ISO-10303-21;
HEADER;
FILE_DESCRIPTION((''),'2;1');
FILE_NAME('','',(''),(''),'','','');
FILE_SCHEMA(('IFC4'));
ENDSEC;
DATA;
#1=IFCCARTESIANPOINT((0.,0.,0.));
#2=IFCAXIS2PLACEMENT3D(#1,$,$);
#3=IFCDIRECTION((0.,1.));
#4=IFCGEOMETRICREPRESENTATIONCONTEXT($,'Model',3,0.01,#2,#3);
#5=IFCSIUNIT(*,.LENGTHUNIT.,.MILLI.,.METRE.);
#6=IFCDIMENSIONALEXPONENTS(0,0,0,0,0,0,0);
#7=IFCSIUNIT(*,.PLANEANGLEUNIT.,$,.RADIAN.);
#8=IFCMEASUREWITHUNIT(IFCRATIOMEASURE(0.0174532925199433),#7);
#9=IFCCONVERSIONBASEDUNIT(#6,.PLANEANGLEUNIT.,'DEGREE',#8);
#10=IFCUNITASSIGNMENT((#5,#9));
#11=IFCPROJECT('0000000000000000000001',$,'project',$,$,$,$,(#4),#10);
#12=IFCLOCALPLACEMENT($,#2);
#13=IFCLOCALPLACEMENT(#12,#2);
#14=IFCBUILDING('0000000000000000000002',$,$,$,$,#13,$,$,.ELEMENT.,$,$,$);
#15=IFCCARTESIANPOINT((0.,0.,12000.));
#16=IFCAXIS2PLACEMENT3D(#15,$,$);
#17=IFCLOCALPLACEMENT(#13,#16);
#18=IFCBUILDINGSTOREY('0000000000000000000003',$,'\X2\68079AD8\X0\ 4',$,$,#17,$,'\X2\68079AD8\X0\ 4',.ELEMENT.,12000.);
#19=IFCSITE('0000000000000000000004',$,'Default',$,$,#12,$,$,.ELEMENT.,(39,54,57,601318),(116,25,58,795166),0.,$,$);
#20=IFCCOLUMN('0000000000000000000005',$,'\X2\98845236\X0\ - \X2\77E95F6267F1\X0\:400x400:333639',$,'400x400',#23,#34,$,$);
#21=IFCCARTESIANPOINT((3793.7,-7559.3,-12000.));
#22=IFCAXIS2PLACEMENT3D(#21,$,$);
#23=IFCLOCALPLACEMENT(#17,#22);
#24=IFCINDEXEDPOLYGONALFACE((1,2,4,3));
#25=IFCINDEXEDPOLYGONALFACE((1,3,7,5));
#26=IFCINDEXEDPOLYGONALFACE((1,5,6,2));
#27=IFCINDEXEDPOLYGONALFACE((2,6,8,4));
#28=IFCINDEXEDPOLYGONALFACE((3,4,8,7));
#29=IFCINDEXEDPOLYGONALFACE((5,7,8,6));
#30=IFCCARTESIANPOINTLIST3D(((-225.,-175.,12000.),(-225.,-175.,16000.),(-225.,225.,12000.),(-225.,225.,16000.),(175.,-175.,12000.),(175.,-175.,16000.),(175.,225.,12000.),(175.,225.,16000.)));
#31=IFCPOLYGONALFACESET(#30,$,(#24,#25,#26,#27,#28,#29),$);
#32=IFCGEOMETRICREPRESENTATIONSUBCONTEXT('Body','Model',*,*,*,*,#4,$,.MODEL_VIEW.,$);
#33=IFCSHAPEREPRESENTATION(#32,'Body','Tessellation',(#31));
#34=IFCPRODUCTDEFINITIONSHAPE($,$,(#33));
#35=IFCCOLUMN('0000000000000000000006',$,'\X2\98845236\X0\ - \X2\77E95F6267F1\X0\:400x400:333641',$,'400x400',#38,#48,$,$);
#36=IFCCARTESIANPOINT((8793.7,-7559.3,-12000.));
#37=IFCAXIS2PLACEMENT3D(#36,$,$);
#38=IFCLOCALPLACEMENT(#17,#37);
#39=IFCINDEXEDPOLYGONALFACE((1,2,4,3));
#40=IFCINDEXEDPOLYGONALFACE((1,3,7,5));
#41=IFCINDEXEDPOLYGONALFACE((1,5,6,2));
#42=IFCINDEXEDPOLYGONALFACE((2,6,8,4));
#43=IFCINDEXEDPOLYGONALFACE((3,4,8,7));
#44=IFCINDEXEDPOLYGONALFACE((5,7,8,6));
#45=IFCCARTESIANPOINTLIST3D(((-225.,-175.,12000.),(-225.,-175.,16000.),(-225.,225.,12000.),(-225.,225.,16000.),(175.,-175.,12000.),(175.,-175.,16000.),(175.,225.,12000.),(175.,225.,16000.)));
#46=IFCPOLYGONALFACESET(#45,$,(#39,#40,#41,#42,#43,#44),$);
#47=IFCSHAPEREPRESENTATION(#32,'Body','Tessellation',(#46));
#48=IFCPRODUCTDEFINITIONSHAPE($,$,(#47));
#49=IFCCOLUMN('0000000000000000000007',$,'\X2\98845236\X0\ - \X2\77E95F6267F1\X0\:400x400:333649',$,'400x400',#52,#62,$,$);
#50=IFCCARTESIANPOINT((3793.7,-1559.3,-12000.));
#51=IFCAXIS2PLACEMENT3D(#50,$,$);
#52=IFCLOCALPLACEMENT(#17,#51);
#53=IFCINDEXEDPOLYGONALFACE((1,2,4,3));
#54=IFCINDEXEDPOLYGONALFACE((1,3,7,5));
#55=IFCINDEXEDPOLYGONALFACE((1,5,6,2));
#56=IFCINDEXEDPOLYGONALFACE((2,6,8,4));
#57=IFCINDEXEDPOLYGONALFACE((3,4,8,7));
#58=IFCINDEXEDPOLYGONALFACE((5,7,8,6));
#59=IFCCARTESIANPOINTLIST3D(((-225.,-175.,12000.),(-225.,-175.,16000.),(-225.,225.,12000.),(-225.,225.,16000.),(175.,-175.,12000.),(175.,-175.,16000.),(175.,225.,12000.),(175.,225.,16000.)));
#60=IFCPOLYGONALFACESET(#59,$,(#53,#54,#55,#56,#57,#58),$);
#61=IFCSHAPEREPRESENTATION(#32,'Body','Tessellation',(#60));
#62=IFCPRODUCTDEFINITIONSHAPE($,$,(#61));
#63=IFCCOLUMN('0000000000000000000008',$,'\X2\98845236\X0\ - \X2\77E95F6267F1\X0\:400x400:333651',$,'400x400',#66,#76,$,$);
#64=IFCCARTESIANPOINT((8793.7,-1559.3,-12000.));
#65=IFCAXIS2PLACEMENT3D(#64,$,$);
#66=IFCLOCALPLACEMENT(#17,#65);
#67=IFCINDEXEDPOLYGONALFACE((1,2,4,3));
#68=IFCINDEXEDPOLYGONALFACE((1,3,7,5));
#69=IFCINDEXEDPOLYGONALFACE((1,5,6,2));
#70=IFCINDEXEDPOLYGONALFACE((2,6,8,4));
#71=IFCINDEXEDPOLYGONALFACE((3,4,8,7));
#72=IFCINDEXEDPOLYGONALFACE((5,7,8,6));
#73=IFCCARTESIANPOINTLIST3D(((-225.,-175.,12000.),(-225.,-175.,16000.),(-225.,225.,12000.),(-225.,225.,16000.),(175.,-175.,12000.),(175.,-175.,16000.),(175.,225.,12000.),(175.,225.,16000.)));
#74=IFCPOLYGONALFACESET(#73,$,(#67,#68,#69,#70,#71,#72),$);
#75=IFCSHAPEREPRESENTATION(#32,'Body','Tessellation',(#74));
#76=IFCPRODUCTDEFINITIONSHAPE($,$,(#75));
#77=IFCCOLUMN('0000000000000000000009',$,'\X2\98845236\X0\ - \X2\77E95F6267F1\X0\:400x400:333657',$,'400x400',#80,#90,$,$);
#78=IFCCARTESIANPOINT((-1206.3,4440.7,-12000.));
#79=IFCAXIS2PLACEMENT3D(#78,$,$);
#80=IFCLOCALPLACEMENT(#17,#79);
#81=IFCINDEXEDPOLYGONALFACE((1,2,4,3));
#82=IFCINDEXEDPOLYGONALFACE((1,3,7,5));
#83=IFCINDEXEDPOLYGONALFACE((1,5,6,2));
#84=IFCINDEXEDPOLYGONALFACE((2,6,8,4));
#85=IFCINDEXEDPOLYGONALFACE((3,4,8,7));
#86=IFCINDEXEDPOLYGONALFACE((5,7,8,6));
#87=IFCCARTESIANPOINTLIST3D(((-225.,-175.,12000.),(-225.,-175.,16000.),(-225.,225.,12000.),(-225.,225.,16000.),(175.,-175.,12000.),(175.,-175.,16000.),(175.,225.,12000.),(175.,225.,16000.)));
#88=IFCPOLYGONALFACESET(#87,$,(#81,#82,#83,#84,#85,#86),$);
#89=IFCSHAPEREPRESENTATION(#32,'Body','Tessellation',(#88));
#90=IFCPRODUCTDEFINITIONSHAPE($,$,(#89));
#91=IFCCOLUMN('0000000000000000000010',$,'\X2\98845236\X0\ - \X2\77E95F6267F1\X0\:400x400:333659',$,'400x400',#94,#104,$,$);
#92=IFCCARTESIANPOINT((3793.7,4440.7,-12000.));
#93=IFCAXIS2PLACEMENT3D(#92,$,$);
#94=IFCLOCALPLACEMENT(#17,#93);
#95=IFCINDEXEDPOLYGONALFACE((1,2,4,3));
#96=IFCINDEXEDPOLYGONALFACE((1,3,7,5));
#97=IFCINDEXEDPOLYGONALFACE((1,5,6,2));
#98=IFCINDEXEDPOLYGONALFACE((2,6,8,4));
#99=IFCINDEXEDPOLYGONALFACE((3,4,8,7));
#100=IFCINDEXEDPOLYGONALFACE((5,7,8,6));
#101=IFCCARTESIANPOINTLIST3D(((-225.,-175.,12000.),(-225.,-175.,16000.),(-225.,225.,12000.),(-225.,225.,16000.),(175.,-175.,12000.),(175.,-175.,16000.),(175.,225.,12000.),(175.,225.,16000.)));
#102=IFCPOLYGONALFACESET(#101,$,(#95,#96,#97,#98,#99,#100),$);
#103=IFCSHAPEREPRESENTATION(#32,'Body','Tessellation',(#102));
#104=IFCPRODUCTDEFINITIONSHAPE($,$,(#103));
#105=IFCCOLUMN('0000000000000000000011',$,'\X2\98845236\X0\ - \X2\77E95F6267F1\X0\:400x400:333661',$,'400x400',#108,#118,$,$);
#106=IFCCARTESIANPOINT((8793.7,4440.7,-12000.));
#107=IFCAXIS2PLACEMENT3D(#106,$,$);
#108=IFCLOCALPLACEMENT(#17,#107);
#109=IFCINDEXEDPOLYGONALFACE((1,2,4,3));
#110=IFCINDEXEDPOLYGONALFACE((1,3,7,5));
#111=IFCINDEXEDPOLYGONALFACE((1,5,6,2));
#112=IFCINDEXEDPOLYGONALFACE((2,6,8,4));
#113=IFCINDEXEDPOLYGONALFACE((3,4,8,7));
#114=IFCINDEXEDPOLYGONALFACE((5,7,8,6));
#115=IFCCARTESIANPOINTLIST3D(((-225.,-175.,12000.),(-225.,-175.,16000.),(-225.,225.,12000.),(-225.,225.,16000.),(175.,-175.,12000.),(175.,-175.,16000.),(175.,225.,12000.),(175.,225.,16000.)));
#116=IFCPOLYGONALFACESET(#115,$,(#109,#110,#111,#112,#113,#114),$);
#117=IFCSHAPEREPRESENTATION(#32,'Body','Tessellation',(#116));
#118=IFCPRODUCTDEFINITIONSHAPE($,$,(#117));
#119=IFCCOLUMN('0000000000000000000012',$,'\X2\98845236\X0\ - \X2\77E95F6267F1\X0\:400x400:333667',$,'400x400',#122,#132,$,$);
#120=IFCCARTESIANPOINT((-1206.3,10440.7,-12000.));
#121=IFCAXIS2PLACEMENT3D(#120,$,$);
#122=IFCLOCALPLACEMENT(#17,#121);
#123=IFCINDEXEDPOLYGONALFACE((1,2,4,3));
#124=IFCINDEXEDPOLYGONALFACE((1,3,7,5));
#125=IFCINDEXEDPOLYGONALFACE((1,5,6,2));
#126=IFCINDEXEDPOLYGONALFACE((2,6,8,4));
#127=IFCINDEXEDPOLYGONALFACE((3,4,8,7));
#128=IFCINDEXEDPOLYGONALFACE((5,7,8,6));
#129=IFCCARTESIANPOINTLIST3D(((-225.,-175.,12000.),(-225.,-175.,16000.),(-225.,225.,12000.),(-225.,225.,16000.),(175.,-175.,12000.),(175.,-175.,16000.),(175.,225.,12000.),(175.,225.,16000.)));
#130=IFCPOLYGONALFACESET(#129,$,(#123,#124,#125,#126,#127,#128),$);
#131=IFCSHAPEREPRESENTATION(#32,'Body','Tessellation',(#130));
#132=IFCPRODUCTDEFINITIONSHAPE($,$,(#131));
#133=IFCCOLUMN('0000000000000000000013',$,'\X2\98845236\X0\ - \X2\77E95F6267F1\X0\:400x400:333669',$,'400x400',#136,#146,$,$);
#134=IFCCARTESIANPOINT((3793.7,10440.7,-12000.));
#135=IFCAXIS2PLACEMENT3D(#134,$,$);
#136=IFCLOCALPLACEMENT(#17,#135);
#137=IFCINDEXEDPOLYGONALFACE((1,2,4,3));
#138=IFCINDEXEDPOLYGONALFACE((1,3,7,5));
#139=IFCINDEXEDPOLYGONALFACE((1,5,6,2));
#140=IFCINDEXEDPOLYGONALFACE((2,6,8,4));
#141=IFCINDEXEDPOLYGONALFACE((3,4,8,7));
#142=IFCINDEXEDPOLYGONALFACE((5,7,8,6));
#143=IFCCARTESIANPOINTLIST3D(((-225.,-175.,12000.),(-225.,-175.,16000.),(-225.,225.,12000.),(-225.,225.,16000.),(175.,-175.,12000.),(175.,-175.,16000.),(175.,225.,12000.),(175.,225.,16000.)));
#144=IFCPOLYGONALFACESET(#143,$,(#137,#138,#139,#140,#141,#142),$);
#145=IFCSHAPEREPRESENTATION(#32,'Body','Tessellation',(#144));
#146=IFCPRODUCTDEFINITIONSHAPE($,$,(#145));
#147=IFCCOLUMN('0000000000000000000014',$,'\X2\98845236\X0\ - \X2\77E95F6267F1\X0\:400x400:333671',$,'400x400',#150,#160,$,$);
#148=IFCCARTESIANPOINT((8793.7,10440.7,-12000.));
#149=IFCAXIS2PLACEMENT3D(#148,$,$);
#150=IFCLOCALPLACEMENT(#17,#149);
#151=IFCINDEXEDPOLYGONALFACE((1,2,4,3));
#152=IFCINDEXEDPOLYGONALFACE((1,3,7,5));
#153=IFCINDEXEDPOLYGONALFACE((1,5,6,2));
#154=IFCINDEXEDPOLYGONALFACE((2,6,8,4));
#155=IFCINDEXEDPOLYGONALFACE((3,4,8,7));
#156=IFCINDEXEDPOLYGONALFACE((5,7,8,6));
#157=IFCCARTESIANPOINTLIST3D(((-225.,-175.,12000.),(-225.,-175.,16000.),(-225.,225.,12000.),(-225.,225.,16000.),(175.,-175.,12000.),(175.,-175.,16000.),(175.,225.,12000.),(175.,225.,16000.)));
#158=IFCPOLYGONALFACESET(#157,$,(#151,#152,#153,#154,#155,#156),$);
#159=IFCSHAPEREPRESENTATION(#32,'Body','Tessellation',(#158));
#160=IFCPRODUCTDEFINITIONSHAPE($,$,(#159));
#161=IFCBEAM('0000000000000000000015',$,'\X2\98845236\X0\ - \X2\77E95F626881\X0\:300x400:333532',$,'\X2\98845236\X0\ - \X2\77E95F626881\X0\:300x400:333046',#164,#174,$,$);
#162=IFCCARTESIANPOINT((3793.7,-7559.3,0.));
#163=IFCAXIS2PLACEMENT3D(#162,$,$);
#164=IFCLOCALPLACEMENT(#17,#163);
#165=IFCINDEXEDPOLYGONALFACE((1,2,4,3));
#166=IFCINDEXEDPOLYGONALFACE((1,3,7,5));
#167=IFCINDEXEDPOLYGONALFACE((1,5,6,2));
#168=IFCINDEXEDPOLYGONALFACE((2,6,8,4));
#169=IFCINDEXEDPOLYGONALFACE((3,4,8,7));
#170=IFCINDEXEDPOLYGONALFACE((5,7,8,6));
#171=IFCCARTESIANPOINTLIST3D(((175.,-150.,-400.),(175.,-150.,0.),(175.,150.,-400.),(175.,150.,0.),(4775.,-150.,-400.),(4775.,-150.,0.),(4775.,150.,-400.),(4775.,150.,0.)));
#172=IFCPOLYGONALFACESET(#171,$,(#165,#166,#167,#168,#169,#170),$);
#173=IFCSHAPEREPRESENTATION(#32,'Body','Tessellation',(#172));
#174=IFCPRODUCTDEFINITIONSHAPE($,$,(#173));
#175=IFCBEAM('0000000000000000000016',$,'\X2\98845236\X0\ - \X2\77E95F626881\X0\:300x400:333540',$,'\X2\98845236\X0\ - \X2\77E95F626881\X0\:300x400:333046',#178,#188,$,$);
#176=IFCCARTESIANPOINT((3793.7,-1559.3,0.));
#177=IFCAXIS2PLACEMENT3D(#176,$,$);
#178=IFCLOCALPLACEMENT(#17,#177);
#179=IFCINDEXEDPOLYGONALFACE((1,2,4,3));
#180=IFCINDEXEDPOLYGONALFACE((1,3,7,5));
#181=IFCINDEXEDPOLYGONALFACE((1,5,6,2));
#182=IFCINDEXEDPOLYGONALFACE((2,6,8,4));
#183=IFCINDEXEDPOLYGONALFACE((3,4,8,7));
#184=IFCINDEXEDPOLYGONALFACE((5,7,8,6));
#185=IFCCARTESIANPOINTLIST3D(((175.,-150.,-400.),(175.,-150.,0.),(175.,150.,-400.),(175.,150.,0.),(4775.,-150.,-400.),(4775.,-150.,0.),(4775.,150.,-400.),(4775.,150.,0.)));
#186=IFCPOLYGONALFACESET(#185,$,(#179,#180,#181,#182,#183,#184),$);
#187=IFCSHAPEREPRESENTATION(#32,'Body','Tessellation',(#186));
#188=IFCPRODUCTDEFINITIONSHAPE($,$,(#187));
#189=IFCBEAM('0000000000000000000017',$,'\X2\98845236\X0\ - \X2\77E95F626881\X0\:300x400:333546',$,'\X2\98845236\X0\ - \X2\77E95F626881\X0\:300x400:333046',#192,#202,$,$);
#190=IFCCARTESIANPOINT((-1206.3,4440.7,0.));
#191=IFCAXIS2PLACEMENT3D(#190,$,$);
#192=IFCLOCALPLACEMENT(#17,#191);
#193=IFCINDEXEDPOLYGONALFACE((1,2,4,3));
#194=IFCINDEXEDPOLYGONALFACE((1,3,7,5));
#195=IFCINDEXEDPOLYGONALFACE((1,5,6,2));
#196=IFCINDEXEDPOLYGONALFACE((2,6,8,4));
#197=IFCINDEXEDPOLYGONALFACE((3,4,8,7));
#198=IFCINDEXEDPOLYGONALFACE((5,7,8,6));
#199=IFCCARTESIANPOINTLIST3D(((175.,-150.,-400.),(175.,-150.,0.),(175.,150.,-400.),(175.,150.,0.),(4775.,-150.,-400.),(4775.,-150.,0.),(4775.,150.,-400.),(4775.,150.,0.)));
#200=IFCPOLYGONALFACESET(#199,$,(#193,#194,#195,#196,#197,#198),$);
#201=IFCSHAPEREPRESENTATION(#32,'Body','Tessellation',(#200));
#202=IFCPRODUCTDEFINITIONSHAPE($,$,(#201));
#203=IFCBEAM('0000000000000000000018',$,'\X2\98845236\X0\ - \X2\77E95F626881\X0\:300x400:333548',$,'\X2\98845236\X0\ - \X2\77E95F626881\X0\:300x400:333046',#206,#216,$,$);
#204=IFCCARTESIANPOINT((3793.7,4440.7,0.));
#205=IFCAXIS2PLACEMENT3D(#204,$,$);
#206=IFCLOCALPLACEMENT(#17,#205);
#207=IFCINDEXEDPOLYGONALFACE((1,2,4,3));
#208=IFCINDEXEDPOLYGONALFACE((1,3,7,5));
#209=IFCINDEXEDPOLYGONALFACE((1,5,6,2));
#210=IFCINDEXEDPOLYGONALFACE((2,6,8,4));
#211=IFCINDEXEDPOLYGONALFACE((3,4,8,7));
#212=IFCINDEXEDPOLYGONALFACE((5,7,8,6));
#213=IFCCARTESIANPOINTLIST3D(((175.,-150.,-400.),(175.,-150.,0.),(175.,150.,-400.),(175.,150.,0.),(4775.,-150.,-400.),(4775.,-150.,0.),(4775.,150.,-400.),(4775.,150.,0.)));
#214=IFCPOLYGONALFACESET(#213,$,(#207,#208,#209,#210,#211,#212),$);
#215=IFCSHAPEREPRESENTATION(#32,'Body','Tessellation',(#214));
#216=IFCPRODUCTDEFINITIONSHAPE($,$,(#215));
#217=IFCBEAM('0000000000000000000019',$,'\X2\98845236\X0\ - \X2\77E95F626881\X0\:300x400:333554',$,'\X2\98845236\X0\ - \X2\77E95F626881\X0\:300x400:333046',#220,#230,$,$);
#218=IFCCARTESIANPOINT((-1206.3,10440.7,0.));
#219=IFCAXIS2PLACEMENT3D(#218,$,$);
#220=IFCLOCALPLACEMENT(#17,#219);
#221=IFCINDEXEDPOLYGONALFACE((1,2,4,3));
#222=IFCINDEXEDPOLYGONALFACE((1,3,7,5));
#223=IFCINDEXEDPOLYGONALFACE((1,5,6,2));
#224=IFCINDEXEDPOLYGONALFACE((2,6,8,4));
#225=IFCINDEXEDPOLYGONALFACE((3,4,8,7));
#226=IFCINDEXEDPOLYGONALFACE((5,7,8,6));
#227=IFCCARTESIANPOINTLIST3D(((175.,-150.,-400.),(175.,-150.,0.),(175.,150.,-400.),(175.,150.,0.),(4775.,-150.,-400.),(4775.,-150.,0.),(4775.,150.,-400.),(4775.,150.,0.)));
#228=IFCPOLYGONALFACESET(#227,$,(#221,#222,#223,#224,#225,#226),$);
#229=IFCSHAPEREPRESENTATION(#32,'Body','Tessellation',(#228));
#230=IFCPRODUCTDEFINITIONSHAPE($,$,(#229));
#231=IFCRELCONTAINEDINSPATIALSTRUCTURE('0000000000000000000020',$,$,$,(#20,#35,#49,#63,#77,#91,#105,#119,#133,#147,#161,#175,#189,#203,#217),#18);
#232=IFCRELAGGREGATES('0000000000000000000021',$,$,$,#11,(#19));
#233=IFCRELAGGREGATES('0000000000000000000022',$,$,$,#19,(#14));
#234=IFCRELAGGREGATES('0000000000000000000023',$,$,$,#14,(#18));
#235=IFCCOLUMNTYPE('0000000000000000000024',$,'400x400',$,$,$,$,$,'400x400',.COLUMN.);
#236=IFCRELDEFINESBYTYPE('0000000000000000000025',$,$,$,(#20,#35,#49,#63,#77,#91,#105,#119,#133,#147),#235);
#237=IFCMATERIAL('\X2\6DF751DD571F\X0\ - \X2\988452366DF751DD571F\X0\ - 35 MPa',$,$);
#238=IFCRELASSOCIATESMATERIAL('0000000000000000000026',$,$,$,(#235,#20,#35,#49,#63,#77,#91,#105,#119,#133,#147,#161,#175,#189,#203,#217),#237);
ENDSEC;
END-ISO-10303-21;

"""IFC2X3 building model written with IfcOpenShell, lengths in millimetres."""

from ifc_helpers import new_model, entity, si_unit, converted_unit, direction, frame, frame_2d, origin, place, context, subcontext, project, spatial, rectangle, extrude, source, transform, mapped, material, type_object, type_shapes, element, save


model = new_model("IFC2X3")

# Units and contexts
model_context = context("Model", 3, precision=0.01, world=origin(), true_north=direction((0.0, 1.0)))
body_context = subcontext(model_context, "Body", "Model", "MODEL_VIEW")
ifc_project = project(units=[si_unit("LENGTHUNIT", "METRE", prefix="MILLI"), converted_unit("PLANEANGLEUNIT", "DEGREE", entity("IfcRatioMeasure", 0.0174532925199433), si_unit("PLANEANGLEUNIT", "RADIAN"), dimensions=[0, 0, 0, 0, 0, 0, 0])], contexts=[model_context])

# Site, building, storey
site_placement = place(None, origin())
site = spatial("IfcSite", under=ifc_project, at=site_placement, Name="Default", CompositionType="ELEMENT", RefLatitude=(39, 54, 57, 601318), RefLongitude=(116, 25, 58, 795166), RefElevation=0.0)
building_placement = place(site_placement, origin())
building = spatial("IfcBuilding", under=site, at=building_placement, CompositionType="ELEMENT")
storey_placement = place(building_placement, frame((0.0, 0.0, 12000.0)))
storey = spatial("IfcBuildingStorey", under=building, at=storey_placement, Name="标高 4", LongName="标高 4", CompositionType="ELEMENT", Elevation=12000.0)

# Columns
ifc_material_1 = material(Name="混凝土 - 预制混凝土 - 35 MPa")
column_type = type_object("IfcColumnType", Name="400x400", ElementType="400x400", PredefinedType="COLUMN", material=ifc_material_1)
shared_shape = source(origin(), body_context, "Body", "SweptSolid", [
    extrude(rectangle(XDim=400.0, YDim=400.0, at=frame_2d((0.0, 0.0), x_axis=(1.0, 0.0))), frame((-25.0, 25.0, 12000.0)), (0.0, 0.0, 1.0), 4000.0),
])
type_shapes(column_type, [shared_shape])
for number, where, name in (
    (1, (3793.7, -7559.3, -12000.0), "预制 - 矩形柱:400x400:333639"),
    (2, (8793.7, -7559.3, -12000.0), "预制 - 矩形柱:400x400:333641"),
    (3, (3793.7, -1559.3, -12000.0), "预制 - 矩形柱:400x400:333649"),
    (4, (8793.7, -1559.3, -12000.0), "预制 - 矩形柱:400x400:333651"),
    (5, (-1206.3, 4440.7, -12000.0), "预制 - 矩形柱:400x400:333657"),
    (6, (3793.7, 4440.7, -12000.0), "预制 - 矩形柱:400x400:333659"),
    (7, (8793.7, 4440.7, -12000.0), "预制 - 矩形柱:400x400:333661"),
    (8, (-1206.3, 10440.7, -12000.0), "预制 - 矩形柱:400x400:333667"),
    (9, (3793.7, 10440.7, -12000.0), "预制 - 矩形柱:400x400:333669"),
    (10, (8793.7, 10440.7, -12000.0), "预制 - 矩形柱:400x400:333671"),
):
    element("IfcColumn", number, at=place(storey_placement, frame(where)), inside=storey, type_object=column_type, material=ifc_material_1, Name=name, ObjectType="400x400", context=body_context, shape_type="MappedRepresentation", body=[
        mapped(shared_shape, transform((0.0, 0.0, 0.0), scale=1.0)),
    ])

# Beams
beam_1_placement = place(storey_placement, frame((3793.7, -7559.3, 0.0)))
element("IfcBeam", 11, at=beam_1_placement, inside=storey, material=ifc_material_1, Name="预制 - 矩形梁:300x400:333532", ObjectType="预制 - 矩形梁:300x400:333046", context=body_context, shape_type="SweptSolid", body=[
    extrude(rectangle(XDim=400.0, YDim=300.0, at=frame_2d((0.0, 0.0), x_axis=(1.0, 0.0))), frame((175.0, 0.0, -200.0), z_axis=(1.0, 0.0, 0.0), x_axis=(0.0, 0.0, -1.0)), (0.0, 0.0, 1.0), 4600.0),
])
beam_2_placement = place(storey_placement, frame((3793.7, -1559.3, 0.0)))
element("IfcBeam", 12, at=beam_2_placement, inside=storey, material=ifc_material_1, Name="预制 - 矩形梁:300x400:333540", ObjectType="预制 - 矩形梁:300x400:333046", context=body_context, shape_type="SweptSolid", body=[
    extrude(rectangle(XDim=400.0, YDim=300.0, at=frame_2d((0.0, 0.0), x_axis=(1.0, 0.0))), frame((175.0, 0.0, -200.0), z_axis=(1.0, 0.0, 0.0), x_axis=(0.0, 0.0, -1.0)), (0.0, 0.0, 1.0), 4600.0),
])
beam_3_placement = place(storey_placement, frame((-1206.3, 4440.7, 0.0)))
element("IfcBeam", 13, at=beam_3_placement, inside=storey, material=ifc_material_1, Name="预制 - 矩形梁:300x400:333546", ObjectType="预制 - 矩形梁:300x400:333046", context=body_context, shape_type="SweptSolid", body=[
    extrude(rectangle(XDim=400.0, YDim=300.0, at=frame_2d((0.0, 0.0), x_axis=(1.0, 0.0))), frame((175.0, 0.0, -200.0), z_axis=(1.0, 0.0, 0.0), x_axis=(0.0, 0.0, -1.0)), (0.0, 0.0, 1.0), 4600.0),
])
beam_4_placement = place(storey_placement, frame((3793.7, 4440.7, 0.0)))
element("IfcBeam", 14, at=beam_4_placement, inside=storey, material=ifc_material_1, Name="预制 - 矩形梁:300x400:333548", ObjectType="预制 - 矩形梁:300x400:333046", context=body_context, shape_type="SweptSolid", body=[
    extrude(rectangle(XDim=400.0, YDim=300.0, at=frame_2d((0.0, 0.0), x_axis=(1.0, 0.0))), frame((175.0, 0.0, -200.0), z_axis=(1.0, 0.0, 0.0), x_axis=(0.0, 0.0, -1.0)), (0.0, 0.0, 1.0), 4600.0),
])
beam_5_placement = place(storey_placement, frame((-1206.3, 10440.7, 0.0)))
element("IfcBeam", 15, at=beam_5_placement, inside=storey, material=ifc_material_1, Name="预制 - 矩形梁:300x400:333554", ObjectType="预制 - 矩形梁:300x400:333046", context=body_context, shape_type="SweptSolid", body=[
    extrude(rectangle(XDim=400.0, YDim=300.0, at=frame_2d((0.0, 0.0), x_axis=(1.0, 0.0))), frame((175.0, 0.0, -200.0), z_axis=(1.0, 0.0, 0.0), x_axis=(0.0, 0.0, -1.0)), (0.0, 0.0, 1.0), 4600.0),
])

save(model, "model.ifc")
